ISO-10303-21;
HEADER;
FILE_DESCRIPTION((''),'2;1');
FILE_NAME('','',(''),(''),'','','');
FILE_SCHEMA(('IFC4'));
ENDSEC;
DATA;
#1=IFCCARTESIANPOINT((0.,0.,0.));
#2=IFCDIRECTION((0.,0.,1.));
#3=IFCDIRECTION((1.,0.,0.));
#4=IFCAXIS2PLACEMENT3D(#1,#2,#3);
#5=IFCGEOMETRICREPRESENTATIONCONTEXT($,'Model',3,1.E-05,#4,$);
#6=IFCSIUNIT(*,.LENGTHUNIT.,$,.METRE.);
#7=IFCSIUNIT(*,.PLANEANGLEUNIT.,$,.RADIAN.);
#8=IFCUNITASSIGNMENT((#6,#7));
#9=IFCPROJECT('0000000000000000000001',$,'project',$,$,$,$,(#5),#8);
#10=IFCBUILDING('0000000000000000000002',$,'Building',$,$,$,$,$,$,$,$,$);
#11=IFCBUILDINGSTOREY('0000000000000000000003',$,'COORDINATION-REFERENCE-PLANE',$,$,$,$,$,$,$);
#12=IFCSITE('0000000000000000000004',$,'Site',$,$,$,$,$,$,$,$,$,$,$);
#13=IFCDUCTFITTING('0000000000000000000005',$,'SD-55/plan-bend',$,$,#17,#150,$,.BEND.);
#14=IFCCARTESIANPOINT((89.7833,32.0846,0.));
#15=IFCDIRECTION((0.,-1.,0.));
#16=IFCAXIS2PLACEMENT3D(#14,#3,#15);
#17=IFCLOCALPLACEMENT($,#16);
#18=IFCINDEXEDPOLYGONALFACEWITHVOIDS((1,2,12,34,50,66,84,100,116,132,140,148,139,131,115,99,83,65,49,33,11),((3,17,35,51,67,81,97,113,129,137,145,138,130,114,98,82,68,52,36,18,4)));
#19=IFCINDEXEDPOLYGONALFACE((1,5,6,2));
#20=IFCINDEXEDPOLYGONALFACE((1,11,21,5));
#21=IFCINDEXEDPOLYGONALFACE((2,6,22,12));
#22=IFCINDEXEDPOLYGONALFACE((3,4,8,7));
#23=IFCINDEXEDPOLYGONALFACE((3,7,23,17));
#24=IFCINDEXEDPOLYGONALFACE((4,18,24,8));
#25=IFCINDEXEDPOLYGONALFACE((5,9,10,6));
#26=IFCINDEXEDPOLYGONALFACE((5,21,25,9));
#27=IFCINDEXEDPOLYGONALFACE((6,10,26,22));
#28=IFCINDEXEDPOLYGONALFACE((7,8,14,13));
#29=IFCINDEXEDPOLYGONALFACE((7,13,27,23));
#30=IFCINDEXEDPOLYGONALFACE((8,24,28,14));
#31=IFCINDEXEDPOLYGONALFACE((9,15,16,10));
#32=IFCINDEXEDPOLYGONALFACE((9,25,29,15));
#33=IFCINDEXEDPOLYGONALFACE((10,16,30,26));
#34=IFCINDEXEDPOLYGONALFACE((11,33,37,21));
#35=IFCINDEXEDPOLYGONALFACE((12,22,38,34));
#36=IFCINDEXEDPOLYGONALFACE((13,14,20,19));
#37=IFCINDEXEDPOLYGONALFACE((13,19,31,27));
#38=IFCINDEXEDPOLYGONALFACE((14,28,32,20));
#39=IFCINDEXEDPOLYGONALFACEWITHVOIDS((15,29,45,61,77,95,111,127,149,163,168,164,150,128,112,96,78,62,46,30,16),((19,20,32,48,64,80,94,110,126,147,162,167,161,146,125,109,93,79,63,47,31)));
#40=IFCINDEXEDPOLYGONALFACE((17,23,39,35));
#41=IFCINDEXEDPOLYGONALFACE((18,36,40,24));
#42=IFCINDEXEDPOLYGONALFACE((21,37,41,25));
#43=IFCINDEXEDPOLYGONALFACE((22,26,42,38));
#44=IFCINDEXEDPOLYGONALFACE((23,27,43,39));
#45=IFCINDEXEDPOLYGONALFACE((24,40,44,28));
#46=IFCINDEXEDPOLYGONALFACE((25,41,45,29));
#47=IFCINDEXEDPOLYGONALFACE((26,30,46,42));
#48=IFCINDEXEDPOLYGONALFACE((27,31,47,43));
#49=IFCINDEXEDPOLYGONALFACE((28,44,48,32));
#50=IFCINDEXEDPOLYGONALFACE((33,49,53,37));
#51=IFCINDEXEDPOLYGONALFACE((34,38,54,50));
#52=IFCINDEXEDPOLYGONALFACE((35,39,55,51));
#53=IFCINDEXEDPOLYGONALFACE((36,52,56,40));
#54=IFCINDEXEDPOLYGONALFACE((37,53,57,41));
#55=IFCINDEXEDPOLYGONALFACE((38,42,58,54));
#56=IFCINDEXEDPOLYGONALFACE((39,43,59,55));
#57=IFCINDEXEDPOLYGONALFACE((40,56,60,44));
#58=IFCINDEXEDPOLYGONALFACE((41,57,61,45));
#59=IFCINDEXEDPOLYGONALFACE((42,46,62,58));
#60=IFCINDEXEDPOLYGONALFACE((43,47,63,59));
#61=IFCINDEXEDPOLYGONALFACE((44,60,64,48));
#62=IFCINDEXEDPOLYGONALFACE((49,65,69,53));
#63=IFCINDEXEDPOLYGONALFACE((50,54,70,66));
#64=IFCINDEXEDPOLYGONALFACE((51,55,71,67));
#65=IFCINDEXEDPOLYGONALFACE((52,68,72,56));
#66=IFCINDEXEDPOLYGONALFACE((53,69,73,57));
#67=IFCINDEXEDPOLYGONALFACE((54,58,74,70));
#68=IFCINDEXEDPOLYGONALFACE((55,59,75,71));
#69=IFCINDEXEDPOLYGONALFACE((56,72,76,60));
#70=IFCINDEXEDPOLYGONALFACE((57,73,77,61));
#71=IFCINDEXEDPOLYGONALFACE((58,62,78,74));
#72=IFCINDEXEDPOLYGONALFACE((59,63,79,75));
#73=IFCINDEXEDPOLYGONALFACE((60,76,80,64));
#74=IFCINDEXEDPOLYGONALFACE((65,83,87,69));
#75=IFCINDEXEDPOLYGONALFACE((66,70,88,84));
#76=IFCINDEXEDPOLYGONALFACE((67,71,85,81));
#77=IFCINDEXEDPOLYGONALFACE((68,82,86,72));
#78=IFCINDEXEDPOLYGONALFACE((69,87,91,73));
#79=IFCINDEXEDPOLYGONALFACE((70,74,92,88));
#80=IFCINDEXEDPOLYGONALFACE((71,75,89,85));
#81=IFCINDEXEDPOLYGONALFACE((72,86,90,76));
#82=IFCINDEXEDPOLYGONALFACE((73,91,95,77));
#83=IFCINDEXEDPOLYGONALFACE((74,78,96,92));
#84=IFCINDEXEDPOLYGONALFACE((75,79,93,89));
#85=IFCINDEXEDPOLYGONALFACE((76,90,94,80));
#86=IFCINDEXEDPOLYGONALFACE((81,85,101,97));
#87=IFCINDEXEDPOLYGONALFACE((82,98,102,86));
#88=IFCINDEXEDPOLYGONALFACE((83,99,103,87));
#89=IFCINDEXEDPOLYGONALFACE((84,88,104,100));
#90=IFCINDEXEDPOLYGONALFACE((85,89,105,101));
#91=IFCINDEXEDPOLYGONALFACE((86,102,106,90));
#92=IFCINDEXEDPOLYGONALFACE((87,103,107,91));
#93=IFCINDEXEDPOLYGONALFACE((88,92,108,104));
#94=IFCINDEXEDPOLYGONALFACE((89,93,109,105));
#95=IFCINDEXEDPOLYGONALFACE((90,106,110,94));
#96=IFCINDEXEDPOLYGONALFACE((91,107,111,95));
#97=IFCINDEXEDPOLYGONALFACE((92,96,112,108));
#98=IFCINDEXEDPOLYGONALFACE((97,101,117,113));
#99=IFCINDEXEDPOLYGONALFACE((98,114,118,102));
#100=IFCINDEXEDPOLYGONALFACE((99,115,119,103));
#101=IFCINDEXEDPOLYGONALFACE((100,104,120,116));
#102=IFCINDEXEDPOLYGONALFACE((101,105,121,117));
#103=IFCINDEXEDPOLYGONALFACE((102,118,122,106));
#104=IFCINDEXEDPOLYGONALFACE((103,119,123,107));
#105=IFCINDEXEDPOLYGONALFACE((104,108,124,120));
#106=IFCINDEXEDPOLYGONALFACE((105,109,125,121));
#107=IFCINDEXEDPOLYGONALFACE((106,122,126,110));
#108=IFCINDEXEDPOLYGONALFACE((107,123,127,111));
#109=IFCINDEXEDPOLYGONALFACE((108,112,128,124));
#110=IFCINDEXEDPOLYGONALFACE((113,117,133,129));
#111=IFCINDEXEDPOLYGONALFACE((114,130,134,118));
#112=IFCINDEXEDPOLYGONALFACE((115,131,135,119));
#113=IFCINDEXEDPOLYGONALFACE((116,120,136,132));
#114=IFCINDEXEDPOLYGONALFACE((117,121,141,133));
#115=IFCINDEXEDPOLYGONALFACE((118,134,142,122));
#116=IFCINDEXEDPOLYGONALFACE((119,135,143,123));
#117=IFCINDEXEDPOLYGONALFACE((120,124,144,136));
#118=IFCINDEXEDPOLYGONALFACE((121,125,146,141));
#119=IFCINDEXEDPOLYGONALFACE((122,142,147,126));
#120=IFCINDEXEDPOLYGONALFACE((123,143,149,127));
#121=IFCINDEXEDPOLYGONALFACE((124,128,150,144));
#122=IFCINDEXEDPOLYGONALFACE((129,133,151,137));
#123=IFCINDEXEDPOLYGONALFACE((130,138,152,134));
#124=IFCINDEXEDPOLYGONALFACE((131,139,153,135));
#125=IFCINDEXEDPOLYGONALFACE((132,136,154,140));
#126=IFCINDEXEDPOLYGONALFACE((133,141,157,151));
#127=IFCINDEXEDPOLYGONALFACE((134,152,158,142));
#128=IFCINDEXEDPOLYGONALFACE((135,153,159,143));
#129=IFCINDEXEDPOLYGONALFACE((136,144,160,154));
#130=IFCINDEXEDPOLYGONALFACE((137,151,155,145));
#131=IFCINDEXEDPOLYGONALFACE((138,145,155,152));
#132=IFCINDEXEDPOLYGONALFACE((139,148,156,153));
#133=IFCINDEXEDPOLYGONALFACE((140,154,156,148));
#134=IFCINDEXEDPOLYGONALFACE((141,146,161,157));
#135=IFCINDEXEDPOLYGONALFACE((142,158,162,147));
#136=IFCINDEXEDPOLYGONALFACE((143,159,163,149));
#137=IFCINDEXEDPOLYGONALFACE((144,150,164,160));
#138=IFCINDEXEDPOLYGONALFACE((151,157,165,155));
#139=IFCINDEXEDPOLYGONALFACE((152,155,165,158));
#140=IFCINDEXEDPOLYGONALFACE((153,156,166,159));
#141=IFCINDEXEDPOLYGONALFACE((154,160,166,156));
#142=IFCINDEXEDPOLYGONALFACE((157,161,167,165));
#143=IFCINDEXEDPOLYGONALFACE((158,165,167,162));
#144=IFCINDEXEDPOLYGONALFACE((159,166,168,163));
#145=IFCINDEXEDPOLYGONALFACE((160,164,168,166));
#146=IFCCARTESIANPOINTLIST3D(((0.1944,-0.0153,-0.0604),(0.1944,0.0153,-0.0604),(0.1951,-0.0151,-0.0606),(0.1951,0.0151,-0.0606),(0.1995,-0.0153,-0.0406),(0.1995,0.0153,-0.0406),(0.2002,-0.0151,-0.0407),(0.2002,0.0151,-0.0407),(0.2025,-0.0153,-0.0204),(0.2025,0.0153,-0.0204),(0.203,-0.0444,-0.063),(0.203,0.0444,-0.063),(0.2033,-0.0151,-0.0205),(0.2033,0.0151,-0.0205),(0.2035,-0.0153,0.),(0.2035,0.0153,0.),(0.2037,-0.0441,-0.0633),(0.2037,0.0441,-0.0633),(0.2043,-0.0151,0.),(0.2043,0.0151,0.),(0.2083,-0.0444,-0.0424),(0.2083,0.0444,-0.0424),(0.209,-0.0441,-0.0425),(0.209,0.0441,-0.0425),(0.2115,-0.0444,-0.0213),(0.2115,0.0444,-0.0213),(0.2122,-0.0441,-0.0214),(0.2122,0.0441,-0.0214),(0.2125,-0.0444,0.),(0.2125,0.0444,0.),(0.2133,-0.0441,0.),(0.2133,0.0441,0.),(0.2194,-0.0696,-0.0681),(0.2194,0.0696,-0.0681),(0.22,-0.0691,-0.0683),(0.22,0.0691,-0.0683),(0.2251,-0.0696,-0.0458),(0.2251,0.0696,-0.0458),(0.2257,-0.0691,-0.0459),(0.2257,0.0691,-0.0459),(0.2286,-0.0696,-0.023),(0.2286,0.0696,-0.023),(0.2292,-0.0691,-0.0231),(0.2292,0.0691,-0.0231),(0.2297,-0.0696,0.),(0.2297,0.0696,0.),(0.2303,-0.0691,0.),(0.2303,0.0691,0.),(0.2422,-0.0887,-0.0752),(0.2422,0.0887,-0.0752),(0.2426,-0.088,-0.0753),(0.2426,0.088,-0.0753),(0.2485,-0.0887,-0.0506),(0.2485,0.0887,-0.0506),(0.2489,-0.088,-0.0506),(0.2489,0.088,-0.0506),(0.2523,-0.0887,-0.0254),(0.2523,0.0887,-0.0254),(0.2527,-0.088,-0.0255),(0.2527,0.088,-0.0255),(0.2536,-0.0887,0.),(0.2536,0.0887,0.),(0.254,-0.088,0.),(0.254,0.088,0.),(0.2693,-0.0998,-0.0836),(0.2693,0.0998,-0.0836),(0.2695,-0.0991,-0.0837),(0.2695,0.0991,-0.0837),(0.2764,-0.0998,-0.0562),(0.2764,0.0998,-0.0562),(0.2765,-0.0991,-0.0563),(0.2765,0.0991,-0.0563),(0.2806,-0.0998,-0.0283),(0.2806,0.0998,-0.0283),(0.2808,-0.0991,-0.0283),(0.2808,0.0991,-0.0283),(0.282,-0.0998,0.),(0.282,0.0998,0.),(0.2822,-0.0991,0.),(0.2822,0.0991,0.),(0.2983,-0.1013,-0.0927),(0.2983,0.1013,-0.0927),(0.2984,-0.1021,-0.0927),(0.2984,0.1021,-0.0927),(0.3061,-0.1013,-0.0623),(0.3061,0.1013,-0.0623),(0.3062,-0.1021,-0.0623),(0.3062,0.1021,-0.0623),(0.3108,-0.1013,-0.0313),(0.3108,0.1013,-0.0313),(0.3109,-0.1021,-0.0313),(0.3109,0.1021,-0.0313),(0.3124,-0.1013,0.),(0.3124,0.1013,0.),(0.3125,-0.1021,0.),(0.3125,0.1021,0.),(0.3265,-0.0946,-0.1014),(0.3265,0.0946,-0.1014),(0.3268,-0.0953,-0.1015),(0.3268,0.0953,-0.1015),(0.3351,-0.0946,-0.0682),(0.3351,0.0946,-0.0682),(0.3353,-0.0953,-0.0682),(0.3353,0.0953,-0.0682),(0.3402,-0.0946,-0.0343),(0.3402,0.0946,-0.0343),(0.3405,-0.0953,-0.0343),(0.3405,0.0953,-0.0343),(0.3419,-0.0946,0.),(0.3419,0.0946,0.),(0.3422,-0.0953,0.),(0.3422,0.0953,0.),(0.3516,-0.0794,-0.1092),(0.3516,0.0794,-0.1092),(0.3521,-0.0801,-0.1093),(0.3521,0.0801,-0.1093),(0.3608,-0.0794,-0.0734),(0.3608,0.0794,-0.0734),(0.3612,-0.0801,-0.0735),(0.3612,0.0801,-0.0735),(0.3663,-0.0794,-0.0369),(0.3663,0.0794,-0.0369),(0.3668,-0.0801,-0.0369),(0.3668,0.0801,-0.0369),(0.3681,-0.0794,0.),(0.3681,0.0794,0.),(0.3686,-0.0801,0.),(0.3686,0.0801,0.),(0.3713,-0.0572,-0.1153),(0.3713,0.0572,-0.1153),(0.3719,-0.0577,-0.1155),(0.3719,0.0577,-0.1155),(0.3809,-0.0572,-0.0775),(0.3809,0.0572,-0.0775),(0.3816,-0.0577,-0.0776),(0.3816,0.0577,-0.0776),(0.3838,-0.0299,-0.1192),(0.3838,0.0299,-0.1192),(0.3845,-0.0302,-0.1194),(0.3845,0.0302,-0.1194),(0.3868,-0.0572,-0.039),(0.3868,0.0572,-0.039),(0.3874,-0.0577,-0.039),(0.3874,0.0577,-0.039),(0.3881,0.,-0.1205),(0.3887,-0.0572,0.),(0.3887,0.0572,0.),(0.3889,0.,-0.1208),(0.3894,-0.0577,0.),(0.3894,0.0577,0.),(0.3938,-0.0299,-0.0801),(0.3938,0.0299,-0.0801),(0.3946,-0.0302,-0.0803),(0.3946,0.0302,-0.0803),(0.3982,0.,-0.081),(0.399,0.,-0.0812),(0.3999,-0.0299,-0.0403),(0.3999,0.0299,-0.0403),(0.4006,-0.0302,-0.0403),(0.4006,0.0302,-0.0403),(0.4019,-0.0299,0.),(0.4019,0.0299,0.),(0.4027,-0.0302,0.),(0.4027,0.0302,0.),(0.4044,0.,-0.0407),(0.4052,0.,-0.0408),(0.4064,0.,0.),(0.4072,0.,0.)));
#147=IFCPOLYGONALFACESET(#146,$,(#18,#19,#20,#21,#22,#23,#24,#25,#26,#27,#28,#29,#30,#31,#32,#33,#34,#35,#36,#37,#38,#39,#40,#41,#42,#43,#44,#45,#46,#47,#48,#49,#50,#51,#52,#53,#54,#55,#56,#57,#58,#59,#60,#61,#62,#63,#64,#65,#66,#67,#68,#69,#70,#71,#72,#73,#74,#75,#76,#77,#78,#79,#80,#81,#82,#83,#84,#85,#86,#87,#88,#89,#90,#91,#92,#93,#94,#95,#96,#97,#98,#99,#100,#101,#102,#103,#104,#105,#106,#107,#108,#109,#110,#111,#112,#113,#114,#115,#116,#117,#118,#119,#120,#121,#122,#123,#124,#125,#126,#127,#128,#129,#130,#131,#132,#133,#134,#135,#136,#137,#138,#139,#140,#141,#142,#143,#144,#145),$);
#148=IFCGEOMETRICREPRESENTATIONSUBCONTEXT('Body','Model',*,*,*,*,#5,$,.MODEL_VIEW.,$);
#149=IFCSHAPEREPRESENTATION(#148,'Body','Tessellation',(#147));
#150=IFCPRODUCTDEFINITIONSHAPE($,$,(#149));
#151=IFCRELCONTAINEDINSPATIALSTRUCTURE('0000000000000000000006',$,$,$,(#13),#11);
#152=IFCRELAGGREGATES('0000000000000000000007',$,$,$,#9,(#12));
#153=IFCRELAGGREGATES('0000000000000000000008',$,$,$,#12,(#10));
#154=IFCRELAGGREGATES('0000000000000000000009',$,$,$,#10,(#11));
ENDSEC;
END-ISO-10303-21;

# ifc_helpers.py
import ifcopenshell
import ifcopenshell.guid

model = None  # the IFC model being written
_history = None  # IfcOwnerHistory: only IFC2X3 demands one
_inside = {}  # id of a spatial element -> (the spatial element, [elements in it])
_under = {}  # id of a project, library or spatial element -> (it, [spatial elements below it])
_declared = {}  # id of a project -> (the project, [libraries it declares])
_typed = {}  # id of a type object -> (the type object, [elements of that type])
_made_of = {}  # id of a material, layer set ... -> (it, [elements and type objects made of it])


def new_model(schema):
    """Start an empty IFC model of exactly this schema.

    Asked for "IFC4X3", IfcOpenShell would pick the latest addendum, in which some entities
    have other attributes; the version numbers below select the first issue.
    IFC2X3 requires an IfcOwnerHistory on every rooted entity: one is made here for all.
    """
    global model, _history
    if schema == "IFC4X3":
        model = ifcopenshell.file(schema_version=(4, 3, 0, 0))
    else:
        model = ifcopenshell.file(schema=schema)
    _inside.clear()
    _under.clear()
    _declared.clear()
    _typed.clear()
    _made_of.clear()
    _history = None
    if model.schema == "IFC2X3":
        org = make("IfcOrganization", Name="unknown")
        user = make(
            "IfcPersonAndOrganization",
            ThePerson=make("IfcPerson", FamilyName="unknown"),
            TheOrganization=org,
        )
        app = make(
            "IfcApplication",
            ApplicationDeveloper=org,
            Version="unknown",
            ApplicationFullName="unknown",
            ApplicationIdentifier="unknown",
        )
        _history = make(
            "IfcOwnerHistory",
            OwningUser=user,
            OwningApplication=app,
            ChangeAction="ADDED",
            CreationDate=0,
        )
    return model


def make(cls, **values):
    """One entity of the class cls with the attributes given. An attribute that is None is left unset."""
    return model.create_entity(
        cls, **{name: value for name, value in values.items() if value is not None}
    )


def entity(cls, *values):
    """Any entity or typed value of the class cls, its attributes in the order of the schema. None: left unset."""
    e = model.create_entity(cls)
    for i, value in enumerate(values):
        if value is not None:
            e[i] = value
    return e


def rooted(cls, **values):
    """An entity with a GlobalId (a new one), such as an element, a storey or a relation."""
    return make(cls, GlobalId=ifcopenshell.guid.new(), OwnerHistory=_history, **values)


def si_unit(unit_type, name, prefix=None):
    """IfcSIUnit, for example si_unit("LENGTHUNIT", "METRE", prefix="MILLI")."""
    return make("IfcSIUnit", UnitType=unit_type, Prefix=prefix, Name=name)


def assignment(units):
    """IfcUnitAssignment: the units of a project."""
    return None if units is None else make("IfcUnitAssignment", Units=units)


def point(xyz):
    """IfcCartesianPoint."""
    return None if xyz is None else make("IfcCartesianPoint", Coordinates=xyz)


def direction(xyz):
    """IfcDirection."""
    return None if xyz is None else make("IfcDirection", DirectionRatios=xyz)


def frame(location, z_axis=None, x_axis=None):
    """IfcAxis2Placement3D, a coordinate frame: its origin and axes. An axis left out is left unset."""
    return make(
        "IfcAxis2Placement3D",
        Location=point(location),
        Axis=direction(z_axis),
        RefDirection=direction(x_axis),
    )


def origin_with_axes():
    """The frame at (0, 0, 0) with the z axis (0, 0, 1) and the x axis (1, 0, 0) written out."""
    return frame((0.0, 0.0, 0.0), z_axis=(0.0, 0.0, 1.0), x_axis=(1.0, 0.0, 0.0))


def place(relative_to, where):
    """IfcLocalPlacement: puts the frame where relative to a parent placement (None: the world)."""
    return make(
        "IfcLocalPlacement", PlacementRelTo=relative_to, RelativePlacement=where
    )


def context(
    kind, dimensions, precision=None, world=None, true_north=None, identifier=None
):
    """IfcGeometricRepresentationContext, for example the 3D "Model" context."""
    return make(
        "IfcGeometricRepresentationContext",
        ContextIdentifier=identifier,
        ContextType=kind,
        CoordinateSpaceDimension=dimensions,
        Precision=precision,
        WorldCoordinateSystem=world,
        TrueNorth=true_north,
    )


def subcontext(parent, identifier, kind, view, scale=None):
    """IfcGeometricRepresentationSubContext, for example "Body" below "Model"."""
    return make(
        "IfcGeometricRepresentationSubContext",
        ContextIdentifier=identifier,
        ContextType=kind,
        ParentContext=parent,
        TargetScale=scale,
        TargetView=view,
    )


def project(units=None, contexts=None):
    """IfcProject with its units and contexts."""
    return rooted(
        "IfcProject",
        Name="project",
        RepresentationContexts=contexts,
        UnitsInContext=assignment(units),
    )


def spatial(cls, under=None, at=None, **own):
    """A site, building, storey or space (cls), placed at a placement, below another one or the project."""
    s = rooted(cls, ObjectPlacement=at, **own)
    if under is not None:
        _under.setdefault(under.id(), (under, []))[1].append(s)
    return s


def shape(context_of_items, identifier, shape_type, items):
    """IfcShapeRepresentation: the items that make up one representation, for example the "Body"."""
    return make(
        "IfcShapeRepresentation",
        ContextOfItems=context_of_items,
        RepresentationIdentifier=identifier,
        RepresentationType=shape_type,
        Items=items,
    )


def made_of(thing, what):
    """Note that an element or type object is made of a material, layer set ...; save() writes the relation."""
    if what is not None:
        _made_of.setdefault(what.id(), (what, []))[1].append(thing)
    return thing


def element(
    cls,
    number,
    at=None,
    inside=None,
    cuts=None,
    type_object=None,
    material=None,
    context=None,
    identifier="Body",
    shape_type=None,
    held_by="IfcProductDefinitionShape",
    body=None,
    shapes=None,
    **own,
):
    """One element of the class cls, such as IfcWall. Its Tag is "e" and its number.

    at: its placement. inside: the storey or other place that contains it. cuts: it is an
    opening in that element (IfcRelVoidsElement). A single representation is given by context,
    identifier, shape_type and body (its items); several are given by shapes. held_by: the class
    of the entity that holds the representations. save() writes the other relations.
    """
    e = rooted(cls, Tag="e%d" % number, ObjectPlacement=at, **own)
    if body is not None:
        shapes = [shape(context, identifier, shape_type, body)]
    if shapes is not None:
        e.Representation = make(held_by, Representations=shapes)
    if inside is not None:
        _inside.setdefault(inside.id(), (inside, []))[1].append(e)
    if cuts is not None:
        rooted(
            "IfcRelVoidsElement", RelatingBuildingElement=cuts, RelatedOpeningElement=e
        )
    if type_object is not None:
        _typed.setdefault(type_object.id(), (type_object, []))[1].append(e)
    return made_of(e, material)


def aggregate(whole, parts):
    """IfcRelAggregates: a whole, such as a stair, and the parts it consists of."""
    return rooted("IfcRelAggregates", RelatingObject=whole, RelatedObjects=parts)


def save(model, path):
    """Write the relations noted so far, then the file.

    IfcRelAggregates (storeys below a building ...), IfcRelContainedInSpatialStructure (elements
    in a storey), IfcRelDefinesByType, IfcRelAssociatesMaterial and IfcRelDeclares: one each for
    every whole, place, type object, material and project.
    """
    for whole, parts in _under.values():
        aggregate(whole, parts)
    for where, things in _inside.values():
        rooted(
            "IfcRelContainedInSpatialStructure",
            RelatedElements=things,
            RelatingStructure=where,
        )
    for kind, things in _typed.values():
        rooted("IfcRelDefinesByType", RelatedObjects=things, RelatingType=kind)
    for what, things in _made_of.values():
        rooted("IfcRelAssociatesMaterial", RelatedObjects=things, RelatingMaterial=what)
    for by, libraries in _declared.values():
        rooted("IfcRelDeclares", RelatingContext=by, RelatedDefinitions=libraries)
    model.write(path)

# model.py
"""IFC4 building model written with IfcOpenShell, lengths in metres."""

from ifc_helpers import new_model, entity, si_unit, frame, origin_with_axes, place, context, subcontext, project, spatial, element, save


model = new_model("IFC4")

# Units and contexts
model_context = context("Model", 3, precision=1e-05, world=origin_with_axes())
body_context = subcontext(model_context, "Body", "Model", "MODEL_VIEW")
ifc_project = project(units=[si_unit("LENGTHUNIT", "METRE"), si_unit("PLANEANGLEUNIT", "RADIAN")], contexts=[model_context])

# Site, building, storey
site = spatial("IfcSite", under=ifc_project, Name="Site")
building = spatial("IfcBuilding", under=site, Name="Building")
storey = spatial("IfcBuildingStorey", under=building, Name="COORDINATION-REFERENCE-PLANE")

# Duct fitting
duct_fitting_1_placement = place(None, frame((89.7833, 32.0846, 0.0), z_axis=(1.0, 0.0, 0.0), x_axis=(0.0, -1.0, 0.0)))
element("IfcDuctFitting", 1, at=duct_fitting_1_placement, inside=storey, Name="SD-55/plan-bend", PredefinedType="BEND", context=body_context, shape_type="SweptSolid", body=[
    entity("IfcRevolvedAreaSolid", entity("IfcCircleHollowProfileDef", "AREA", None, entity("IfcAxis2Placement2D", entity("IfcCartesianPoint", [0.3048, 0.0])), 0.1024, 0.0008), entity("IfcAxis2Placement3D", entity("IfcCartesianPoint", [0.0, 0.0, 0.0]), entity("IfcDirection", [0.0, 0.0, 1.0]), entity("IfcDirection", [1.0, 0.0, 0.0])), entity("IfcAxis1Placement", entity("IfcCartesianPoint", [0.0, 0.0, 0.0]), entity("IfcDirection", [0.0, 1.0, 0.0])), 0.301119),
])

save(model, "model.ifc")
